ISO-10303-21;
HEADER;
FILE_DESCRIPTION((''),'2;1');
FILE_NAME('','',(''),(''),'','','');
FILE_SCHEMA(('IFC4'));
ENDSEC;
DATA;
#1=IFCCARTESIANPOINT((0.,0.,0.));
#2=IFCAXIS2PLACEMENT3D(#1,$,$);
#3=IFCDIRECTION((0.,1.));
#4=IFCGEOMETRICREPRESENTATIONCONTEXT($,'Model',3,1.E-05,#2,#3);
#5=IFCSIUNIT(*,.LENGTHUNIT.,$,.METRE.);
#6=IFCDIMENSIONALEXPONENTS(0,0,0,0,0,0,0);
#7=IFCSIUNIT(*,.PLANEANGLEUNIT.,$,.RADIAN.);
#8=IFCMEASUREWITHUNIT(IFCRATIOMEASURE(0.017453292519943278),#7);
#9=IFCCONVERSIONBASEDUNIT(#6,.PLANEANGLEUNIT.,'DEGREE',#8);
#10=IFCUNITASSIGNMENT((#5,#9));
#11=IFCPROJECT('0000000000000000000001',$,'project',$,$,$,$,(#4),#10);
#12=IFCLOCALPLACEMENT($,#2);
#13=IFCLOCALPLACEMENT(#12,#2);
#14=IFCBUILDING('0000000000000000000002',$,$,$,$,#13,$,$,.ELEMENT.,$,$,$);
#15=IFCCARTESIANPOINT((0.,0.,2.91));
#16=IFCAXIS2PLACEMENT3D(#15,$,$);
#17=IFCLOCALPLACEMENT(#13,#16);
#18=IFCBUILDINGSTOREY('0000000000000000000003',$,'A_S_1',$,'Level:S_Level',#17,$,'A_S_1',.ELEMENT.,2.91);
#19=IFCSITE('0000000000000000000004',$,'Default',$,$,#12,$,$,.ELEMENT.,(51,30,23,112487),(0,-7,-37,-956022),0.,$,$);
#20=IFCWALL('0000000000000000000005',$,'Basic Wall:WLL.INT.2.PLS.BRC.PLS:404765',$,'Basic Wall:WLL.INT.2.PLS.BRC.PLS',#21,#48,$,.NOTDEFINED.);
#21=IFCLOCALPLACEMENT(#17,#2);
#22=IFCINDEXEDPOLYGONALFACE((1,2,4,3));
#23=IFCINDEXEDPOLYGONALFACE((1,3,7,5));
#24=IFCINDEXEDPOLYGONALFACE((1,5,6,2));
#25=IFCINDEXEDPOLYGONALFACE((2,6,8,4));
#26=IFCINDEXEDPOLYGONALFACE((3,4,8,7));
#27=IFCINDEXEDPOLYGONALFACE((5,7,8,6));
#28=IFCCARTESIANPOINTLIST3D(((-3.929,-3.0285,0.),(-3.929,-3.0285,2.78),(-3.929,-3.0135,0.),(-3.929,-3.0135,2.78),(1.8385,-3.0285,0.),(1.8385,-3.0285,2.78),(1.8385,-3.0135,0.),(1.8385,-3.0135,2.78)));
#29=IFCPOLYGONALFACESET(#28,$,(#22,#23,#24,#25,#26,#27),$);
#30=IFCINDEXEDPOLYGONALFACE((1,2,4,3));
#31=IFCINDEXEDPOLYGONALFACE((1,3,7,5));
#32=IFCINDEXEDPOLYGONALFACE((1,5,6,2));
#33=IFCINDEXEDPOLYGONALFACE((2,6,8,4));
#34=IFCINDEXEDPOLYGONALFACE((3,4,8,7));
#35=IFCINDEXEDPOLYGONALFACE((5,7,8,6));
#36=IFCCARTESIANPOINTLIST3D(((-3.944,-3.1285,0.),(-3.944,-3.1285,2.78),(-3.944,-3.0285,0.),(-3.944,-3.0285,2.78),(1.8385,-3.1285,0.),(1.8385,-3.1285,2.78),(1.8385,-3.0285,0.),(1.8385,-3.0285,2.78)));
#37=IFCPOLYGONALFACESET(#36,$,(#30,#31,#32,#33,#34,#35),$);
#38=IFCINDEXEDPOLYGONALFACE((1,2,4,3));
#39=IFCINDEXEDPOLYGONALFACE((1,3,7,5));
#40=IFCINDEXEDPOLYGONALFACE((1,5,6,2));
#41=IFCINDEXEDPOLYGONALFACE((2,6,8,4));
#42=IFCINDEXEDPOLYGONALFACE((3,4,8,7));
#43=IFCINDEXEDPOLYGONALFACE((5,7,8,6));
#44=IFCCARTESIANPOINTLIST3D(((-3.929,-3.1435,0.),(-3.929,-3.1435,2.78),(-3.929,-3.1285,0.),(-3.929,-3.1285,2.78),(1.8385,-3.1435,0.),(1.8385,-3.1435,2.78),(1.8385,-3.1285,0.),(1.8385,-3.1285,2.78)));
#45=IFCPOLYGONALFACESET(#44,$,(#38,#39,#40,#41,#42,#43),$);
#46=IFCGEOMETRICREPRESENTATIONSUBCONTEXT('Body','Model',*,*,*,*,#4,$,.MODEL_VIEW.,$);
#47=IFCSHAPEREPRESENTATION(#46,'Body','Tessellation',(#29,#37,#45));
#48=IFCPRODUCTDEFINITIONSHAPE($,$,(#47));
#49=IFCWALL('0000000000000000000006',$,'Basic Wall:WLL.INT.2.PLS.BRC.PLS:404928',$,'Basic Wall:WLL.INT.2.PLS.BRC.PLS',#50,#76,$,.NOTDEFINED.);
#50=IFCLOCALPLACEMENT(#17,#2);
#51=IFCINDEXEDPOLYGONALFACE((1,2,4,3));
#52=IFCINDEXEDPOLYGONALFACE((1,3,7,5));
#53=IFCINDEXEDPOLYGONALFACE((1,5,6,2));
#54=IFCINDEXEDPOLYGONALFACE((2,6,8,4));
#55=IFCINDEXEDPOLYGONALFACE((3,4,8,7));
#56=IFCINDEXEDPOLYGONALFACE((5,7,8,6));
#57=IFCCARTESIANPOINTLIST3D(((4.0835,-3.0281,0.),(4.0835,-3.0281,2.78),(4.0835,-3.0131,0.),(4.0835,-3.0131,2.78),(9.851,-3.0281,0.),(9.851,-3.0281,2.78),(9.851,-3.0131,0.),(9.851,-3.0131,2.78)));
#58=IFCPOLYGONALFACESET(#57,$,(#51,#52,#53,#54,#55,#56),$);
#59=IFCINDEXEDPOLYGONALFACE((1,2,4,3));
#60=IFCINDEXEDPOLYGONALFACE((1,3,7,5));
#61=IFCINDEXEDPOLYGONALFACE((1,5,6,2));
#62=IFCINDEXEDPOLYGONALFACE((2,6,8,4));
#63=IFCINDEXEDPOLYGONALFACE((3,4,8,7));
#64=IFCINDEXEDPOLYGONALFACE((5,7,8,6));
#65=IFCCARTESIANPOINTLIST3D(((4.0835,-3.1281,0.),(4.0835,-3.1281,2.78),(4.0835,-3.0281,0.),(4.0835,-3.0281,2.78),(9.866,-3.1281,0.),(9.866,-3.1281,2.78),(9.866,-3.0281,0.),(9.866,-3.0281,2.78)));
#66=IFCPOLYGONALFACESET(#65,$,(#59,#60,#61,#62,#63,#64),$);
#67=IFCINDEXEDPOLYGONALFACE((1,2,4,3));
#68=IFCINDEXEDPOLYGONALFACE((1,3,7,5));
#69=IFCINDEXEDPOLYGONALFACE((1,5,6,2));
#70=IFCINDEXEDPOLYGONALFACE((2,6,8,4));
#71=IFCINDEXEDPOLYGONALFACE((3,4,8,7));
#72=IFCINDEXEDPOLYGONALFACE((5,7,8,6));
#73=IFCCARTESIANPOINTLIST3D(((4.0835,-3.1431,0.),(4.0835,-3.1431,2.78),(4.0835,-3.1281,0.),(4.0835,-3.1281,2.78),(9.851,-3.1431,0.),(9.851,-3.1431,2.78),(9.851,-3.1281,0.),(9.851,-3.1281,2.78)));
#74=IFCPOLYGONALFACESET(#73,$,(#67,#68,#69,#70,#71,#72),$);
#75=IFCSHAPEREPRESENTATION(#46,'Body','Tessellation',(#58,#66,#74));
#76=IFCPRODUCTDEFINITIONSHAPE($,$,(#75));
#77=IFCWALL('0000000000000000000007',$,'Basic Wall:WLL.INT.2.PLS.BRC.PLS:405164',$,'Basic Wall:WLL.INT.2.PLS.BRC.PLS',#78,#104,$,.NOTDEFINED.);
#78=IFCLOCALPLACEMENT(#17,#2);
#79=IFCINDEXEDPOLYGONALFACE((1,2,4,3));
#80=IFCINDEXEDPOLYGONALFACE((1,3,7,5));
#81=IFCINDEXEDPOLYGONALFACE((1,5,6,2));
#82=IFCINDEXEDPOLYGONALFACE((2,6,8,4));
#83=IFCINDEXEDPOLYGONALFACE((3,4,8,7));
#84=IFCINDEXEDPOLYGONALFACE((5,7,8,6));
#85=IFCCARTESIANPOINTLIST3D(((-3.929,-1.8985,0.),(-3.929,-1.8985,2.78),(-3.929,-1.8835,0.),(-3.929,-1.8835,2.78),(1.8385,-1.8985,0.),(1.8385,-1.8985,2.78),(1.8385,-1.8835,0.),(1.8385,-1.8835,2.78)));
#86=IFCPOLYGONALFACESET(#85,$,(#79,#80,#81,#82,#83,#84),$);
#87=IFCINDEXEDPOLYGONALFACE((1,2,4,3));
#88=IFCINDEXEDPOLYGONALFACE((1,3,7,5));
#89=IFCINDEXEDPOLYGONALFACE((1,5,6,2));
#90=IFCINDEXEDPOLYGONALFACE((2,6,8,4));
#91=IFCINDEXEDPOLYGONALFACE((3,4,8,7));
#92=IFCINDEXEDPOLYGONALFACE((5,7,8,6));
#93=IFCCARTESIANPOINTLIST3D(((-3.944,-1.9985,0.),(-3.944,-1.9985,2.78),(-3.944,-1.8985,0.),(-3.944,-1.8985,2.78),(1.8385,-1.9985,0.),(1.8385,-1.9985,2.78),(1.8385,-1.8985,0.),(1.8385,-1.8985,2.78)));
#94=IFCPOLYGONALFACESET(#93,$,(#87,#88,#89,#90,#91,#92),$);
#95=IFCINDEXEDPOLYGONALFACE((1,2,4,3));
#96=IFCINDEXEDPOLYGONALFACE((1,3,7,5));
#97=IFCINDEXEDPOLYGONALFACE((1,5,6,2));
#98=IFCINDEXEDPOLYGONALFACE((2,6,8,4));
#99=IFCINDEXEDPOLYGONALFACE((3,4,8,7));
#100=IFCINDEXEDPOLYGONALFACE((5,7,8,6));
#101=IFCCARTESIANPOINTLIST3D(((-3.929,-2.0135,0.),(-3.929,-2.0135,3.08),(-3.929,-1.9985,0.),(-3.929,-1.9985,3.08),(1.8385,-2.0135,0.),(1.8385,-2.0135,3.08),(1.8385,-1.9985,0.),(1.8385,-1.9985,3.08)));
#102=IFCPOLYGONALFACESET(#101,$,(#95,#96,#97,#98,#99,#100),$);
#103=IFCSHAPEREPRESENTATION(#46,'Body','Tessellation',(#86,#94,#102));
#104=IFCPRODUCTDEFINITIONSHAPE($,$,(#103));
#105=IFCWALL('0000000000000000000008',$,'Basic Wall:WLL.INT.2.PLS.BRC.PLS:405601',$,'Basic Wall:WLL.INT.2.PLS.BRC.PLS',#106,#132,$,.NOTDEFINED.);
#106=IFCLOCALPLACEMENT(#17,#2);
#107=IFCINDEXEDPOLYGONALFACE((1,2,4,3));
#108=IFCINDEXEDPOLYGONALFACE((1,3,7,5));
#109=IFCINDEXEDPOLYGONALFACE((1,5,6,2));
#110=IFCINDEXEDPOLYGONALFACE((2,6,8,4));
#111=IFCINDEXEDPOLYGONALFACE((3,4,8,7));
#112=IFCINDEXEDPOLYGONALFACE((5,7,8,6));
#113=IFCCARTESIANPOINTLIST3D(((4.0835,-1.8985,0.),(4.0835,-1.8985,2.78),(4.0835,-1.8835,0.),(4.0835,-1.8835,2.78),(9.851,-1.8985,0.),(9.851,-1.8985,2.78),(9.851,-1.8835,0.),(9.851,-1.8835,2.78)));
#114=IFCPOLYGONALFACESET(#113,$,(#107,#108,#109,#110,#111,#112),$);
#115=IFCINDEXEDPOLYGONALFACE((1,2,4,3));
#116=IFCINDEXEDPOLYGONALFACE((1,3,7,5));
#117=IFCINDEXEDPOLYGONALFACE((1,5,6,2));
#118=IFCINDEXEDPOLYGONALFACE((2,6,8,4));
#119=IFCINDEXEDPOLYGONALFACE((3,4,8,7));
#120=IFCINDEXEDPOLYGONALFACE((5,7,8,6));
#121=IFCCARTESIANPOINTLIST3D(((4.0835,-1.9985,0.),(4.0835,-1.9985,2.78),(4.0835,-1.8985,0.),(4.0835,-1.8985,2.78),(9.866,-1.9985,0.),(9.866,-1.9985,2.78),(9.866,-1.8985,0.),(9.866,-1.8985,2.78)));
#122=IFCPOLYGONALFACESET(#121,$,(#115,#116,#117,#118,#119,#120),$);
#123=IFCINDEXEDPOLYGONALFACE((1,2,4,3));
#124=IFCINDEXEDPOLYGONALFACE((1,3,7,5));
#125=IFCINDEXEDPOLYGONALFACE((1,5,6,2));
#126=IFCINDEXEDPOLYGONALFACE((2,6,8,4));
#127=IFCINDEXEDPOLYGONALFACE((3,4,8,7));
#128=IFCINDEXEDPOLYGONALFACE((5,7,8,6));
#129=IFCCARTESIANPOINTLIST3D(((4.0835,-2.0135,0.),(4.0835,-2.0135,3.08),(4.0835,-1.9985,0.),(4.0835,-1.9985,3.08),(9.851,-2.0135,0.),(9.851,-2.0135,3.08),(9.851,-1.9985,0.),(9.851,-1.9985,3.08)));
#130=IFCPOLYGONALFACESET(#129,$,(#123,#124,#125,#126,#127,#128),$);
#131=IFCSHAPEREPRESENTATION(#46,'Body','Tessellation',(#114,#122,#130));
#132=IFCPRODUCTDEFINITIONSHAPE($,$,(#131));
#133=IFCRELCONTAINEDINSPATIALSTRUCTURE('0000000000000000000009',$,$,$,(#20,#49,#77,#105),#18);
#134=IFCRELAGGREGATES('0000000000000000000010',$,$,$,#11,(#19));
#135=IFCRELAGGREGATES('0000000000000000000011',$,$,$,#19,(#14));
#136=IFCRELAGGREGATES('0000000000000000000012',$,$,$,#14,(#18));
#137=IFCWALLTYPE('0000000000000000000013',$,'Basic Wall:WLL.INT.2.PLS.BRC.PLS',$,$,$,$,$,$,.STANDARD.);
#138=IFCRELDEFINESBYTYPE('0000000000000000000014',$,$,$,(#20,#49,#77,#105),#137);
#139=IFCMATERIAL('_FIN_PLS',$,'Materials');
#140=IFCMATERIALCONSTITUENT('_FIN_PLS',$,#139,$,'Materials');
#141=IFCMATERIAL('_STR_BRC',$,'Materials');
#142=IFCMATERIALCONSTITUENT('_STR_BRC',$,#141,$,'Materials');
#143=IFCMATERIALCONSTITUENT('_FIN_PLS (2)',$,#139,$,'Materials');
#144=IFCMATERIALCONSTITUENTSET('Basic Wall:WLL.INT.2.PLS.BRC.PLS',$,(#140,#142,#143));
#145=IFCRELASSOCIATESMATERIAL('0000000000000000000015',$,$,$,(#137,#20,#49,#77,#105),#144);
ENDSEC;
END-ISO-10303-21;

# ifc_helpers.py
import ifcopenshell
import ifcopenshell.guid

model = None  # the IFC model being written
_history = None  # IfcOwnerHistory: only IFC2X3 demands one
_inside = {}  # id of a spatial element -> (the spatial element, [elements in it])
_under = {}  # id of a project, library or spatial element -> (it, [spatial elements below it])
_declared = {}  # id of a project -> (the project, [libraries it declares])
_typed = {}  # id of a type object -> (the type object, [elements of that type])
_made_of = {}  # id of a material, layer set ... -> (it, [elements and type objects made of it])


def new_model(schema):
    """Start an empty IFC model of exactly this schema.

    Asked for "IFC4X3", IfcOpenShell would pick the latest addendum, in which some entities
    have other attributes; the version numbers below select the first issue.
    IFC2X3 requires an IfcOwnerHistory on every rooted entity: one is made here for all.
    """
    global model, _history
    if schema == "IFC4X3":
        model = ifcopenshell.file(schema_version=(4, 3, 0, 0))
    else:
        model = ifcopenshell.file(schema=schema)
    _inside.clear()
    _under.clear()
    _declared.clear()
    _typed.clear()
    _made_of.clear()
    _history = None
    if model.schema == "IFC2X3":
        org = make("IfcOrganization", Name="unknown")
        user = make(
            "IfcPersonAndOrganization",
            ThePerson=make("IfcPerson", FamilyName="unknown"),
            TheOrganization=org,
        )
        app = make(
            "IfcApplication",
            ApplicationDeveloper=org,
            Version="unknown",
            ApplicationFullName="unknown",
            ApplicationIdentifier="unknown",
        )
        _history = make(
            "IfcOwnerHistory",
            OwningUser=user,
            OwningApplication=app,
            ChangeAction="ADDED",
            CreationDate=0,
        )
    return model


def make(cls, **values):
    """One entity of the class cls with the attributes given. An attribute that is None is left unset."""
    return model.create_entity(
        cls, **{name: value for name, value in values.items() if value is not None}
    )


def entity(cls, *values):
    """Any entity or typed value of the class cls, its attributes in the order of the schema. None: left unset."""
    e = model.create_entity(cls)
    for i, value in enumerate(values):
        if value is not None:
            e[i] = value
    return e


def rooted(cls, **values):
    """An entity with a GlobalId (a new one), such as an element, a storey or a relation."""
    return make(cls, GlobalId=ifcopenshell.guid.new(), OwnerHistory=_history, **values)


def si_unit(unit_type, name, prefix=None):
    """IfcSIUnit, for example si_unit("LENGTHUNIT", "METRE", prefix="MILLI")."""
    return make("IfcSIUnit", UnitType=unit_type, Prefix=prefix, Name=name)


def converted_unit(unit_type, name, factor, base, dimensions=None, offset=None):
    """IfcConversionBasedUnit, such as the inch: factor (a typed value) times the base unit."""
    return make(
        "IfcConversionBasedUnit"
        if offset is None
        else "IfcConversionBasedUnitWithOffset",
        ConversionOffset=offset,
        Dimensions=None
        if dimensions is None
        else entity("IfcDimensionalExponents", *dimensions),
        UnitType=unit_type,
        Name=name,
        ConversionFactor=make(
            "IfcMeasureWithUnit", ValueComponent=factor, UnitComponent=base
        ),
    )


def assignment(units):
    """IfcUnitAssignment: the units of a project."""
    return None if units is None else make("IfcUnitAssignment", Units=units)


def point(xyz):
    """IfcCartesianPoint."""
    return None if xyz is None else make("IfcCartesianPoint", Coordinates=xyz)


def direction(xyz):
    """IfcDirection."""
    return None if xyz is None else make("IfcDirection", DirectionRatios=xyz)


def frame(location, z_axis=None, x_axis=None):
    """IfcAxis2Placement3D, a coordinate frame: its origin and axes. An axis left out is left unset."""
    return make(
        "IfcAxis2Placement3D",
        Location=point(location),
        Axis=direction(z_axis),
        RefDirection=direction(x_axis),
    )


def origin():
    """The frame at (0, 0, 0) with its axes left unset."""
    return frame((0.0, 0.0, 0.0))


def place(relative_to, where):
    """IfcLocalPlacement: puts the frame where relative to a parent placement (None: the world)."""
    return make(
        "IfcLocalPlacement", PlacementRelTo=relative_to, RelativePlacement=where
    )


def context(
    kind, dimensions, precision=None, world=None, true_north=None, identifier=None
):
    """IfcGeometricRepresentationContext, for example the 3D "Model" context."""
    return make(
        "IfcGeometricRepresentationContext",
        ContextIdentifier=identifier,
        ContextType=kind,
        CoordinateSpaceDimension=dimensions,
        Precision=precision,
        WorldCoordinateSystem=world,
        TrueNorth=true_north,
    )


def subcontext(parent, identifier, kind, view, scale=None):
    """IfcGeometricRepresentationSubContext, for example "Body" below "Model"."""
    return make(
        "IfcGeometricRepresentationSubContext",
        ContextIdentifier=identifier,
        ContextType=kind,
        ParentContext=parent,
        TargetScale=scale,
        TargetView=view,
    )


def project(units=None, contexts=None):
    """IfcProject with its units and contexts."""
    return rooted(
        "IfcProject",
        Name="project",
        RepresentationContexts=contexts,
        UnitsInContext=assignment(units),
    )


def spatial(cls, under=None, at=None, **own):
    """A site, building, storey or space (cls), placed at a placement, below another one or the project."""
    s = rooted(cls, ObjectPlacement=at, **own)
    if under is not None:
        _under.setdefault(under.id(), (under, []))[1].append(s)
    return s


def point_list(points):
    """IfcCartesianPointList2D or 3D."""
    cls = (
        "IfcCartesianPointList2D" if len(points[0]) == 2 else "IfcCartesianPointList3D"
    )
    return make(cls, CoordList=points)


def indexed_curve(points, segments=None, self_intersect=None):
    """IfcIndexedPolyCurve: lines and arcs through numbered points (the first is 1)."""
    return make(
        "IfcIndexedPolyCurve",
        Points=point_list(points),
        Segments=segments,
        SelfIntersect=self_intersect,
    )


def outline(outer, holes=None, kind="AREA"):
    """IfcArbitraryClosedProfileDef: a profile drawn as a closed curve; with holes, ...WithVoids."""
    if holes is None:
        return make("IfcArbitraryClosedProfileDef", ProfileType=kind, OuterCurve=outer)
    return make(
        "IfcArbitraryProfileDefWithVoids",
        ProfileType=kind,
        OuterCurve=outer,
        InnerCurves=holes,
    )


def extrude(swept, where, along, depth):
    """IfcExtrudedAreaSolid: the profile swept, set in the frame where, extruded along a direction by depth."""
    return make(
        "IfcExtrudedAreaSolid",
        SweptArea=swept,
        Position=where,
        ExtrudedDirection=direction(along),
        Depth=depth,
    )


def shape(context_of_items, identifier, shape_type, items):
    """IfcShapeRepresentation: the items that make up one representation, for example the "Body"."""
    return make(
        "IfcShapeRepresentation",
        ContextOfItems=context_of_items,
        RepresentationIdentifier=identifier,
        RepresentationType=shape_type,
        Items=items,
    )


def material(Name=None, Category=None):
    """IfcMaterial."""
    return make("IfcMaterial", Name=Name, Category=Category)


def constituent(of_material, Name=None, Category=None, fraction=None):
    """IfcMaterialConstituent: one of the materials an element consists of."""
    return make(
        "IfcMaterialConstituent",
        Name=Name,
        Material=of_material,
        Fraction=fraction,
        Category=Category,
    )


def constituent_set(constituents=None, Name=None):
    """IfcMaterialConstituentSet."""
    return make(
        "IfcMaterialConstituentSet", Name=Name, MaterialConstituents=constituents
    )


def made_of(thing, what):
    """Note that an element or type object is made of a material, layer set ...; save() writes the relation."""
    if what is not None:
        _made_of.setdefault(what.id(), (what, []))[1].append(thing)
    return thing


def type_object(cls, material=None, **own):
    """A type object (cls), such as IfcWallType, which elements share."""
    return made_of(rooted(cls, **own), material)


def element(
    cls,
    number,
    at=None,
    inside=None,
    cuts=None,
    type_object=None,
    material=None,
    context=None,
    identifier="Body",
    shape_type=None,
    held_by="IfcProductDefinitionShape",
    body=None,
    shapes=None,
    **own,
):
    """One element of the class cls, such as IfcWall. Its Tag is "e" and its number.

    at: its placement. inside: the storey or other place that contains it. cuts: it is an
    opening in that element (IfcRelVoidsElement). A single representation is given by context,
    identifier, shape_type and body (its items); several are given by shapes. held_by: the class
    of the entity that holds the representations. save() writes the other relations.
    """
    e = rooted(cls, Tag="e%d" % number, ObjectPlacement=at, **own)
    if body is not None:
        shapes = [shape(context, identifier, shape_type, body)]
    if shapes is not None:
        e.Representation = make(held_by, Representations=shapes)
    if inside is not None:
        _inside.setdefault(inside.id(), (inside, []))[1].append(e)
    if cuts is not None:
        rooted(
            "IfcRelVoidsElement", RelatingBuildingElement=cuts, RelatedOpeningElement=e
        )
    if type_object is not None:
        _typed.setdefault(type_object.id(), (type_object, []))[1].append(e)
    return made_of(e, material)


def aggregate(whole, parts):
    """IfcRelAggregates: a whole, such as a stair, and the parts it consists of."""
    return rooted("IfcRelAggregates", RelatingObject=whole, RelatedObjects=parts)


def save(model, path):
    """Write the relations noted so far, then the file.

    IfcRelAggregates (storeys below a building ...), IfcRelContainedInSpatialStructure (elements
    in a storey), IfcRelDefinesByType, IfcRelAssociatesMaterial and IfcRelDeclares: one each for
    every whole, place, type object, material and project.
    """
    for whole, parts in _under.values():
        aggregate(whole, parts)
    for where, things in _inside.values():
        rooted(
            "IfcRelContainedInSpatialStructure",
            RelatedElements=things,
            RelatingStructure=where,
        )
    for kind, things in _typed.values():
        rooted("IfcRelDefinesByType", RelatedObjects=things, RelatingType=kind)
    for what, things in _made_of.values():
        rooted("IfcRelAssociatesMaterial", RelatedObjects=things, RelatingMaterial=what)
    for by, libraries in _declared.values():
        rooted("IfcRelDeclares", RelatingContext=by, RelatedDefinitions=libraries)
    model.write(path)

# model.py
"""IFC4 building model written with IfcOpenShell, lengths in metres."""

from ifc_helpers import new_model, entity, si_unit, converted_unit, direction, frame, origin, place, context, subcontext, project, spatial, indexed_curve, outline, extrude, material, constituent, constituent_set, type_object, element, save


model = new_model("IFC4")

# Units and contexts
model_context = context("Model", 3, precision=1e-05, world=origin(), true_north=direction((0.0, 1.0)))
body_context = subcontext(model_context, "Body", "Model", "MODEL_VIEW")
ifc_project = project(units=[si_unit("LENGTHUNIT", "METRE"), converted_unit("PLANEANGLEUNIT", "DEGREE", entity("IfcRatioMeasure", 0.017453292519943278), si_unit("PLANEANGLEUNIT", "RADIAN"), dimensions=[0, 0, 0, 0, 0, 0, 0])], contexts=[model_context])

# Site, building, storey
site_placement = place(None, origin())
site = spatial("IfcSite", under=ifc_project, at=site_placement, Name="Default", CompositionType="ELEMENT", RefLatitude=(51, 30, 23, 112487), RefLongitude=(0, -7, -37, -956022), RefElevation=0.0)
building_placement = place(site_placement, origin())
building = spatial("IfcBuilding", under=site, at=building_placement, CompositionType="ELEMENT")
storey_placement = place(building_placement, frame((0.0, 0.0, 2.91)))
storey = spatial("IfcBuildingStorey", under=building, at=storey_placement, Name="A_S_1", ObjectType="Level:S_Level", LongName="A_S_1", CompositionType="ELEMENT", Elevation=2.91)

# Shared definitions
ifc_material_1 = material(Name="_STR_BRC", Category="Materials")
ifc_material_2 = material(Name="_FIN_PLS", Category="Materials")

# Walls
ifc_constituent_1 = constituent(ifc_material_2, Name="_FIN_PLS", Category="Materials")
ifc_constituent_2 = constituent(ifc_material_1, Name="_STR_BRC", Category="Materials")
ifc_constituent_3 = constituent(ifc_material_2, Name="_FIN_PLS (2)", Category="Materials")
ifc_constituent_set_1 = constituent_set(constituents=[ifc_constituent_1, ifc_constituent_2, ifc_constituent_3], Name="Basic Wall:WLL.INT.2.PLS.BRC.PLS")
wall_type = type_object("IfcWallType", Name="Basic Wall:WLL.INT.2.PLS.BRC.PLS", PredefinedType="STANDARD", material=ifc_constituent_set_1)
wall_1_placement = place(storey_placement, frame((-3.929, -3.0785, 0.0)))
element("IfcWall", 1, at=wall_1_placement, inside=storey, type_object=wall_type, material=ifc_constituent_set_1, Name="Basic Wall:WLL.INT.2.PLS.BRC.PLS:404765", ObjectType="Basic Wall:WLL.INT.2.PLS.BRC.PLS", PredefinedType="NOTDEFINED", context=body_context, shape_type="SweptSolid", body=[
    extrude(outline(indexed_curve([(-0.0075, -2.8837), (0.0075, -2.8837), (0.0075, 2.8837), (-0.0075, 2.8837), (-0.0075, -2.8837)], self_intersect=False)), frame((2.8837, 0.0575, 0.0), z_axis=(0.0, 0.0, 1.0), x_axis=(0.0, -1.0, 0.0)), (0.0, 0.0, 1.0), 2.78),
    extrude(outline(indexed_curve([(-2.8912, -0.05), (2.8912, -0.05), (2.8912, 0.05), (-2.8912, 0.05), (-2.8912, -0.05)], self_intersect=False)), frame((2.8762, 0.0, 0.0)), (0.0, 0.0, 1.0), 2.78),
    extrude(outline(indexed_curve([(-0.0075, -2.8837), (0.0075, -2.8837), (0.0075, 2.8837), (-0.0075, 2.8837), (-0.0075, -2.8837)], self_intersect=False)), frame((2.8837, -0.0575, 0.0), z_axis=(0.0, 0.0, 1.0), x_axis=(0.0, 1.0, 0.0)), (0.0, 0.0, 1.0), 2.78),
])
wall_2_placement = place(storey_placement, frame((9.851, -3.0781, 0.0), z_axis=(0.0, 0.0, 1.0), x_axis=(-1.0, 0.0, 0.0)))
element("IfcWall", 2, at=wall_2_placement, inside=storey, type_object=wall_type, material=ifc_constituent_set_1, Name="Basic Wall:WLL.INT.2.PLS.BRC.PLS:404928", ObjectType="Basic Wall:WLL.INT.2.PLS.BRC.PLS", PredefinedType="NOTDEFINED", context=body_context, shape_type="SweptSolid", body=[
    extrude(outline(indexed_curve([(-0.0075, -2.8837), (0.0075, -2.8837), (0.0075, 2.8837), (-0.0075, 2.8837), (-0.0075, -2.8837)], self_intersect=False)), frame((2.8837, -0.0575, 0.0), z_axis=(0.0, 0.0, 1.0), x_axis=(0.0, 1.0, 0.0)), (0.0, 0.0, 1.0), 2.78),
    extrude(outline(indexed_curve([(-2.8912, -0.05), (2.8912, -0.05), (2.8912, 0.05), (-2.8912, 0.05), (-2.8912, -0.05)], self_intersect=False)), frame((2.8762, 0.0, 0.0)), (0.0, 0.0, 1.0), 2.78),
    extrude(outline(indexed_curve([(-0.0075, -2.8837), (0.0075, -2.8837), (0.0075, 2.8837), (-0.0075, 2.8837), (-0.0075, -2.8837)], self_intersect=False)), frame((2.8837, 0.0575, 0.0), z_axis=(0.0, 0.0, 1.0), x_axis=(0.0, -1.0, 0.0)), (0.0, 0.0, 1.0), 2.78),
])
wall_3_placement = place(storey_placement, frame((-3.929, -1.9485, 0.0)))
element("IfcWall", 3, at=wall_3_placement, inside=storey, type_object=wall_type, material=ifc_constituent_set_1, Name="Basic Wall:WLL.INT.2.PLS.BRC.PLS:405164", ObjectType="Basic Wall:WLL.INT.2.PLS.BRC.PLS", PredefinedType="NOTDEFINED", context=body_context, shape_type="SweptSolid", body=[
    extrude(outline(indexed_curve([(-0.0075, -2.8837), (0.0075, -2.8837), (0.0075, 2.8837), (-0.0075, 2.8837), (-0.0075, -2.8837)], self_intersect=False)), frame((2.8837, 0.0575, 0.0), z_axis=(0.0, 0.0, 1.0), x_axis=(0.0, -1.0, 0.0)), (0.0, 0.0, 1.0), 2.78),
    extrude(outline(indexed_curve([(-2.8912, -0.05), (2.8912, -0.05), (2.8912, 0.05), (-2.8912, 0.05), (-2.8912, -0.05)], self_intersect=False)), frame((2.8762, 0.0, 0.0)), (0.0, 0.0, 1.0), 2.78),
    extrude(outline(indexed_curve([(-0.0075, -2.8837), (0.0075, -2.8837), (0.0075, 2.8837), (-0.0075, 2.8837), (-0.0075, -2.8837)], self_intersect=False)), frame((2.8837, -0.0575, 0.0), z_axis=(0.0, 0.0, 1.0), x_axis=(0.0, 1.0, 0.0)), (0.0, 0.0, 1.0), 3.08),
])
wall_4_placement = place(storey_placement, frame((9.851, -1.9485, 0.0), z_axis=(0.0, 0.0, 1.0), x_axis=(-1.0, 0.0, 0.0)))
element("IfcWall", 4, at=wall_4_placement, inside=storey, type_object=wall_type, material=ifc_constituent_set_1, Name="Basic Wall:WLL.INT.2.PLS.BRC.PLS:405601", ObjectType="Basic Wall:WLL.INT.2.PLS.BRC.PLS", PredefinedType="NOTDEFINED", context=body_context, shape_type="SweptSolid", body=[
    extrude(outline(indexed_curve([(-0.0075, -2.8837), (0.0075, -2.8837), (0.0075, 2.8837), (-0.0075, 2.8837), (-0.0075, -2.8837)], self_intersect=False)), frame((2.8837, -0.0575, 0.0), z_axis=(0.0, 0.0, 1.0), x_axis=(0.0, 1.0, 0.0)), (0.0, 0.0, 1.0), 2.78),
    extrude(outline(indexed_curve([(-2.8912, -0.05), (2.8912, -0.05), (2.8912, 0.05), (-2.8912, 0.05), (-2.8912, -0.05)], self_intersect=False)), frame((2.8762, 0.0, 0.0)), (0.0, 0.0, 1.0), 2.78),
    extrude(outline(indexed_curve([(-0.0075, -2.8837), (0.0075, -2.8837), (0.0075, 2.8837), (-0.0075, 2.8837), (-0.0075, -2.8837)], self_intersect=False)), frame((2.8837, 0.0575, 0.0), z_axis=(0.0, 0.0, 1.0), x_axis=(0.0, -1.0, 0.0)), (0.0, 0.0, 1.0), 3.08),
])

save(model, "model.ifc")
